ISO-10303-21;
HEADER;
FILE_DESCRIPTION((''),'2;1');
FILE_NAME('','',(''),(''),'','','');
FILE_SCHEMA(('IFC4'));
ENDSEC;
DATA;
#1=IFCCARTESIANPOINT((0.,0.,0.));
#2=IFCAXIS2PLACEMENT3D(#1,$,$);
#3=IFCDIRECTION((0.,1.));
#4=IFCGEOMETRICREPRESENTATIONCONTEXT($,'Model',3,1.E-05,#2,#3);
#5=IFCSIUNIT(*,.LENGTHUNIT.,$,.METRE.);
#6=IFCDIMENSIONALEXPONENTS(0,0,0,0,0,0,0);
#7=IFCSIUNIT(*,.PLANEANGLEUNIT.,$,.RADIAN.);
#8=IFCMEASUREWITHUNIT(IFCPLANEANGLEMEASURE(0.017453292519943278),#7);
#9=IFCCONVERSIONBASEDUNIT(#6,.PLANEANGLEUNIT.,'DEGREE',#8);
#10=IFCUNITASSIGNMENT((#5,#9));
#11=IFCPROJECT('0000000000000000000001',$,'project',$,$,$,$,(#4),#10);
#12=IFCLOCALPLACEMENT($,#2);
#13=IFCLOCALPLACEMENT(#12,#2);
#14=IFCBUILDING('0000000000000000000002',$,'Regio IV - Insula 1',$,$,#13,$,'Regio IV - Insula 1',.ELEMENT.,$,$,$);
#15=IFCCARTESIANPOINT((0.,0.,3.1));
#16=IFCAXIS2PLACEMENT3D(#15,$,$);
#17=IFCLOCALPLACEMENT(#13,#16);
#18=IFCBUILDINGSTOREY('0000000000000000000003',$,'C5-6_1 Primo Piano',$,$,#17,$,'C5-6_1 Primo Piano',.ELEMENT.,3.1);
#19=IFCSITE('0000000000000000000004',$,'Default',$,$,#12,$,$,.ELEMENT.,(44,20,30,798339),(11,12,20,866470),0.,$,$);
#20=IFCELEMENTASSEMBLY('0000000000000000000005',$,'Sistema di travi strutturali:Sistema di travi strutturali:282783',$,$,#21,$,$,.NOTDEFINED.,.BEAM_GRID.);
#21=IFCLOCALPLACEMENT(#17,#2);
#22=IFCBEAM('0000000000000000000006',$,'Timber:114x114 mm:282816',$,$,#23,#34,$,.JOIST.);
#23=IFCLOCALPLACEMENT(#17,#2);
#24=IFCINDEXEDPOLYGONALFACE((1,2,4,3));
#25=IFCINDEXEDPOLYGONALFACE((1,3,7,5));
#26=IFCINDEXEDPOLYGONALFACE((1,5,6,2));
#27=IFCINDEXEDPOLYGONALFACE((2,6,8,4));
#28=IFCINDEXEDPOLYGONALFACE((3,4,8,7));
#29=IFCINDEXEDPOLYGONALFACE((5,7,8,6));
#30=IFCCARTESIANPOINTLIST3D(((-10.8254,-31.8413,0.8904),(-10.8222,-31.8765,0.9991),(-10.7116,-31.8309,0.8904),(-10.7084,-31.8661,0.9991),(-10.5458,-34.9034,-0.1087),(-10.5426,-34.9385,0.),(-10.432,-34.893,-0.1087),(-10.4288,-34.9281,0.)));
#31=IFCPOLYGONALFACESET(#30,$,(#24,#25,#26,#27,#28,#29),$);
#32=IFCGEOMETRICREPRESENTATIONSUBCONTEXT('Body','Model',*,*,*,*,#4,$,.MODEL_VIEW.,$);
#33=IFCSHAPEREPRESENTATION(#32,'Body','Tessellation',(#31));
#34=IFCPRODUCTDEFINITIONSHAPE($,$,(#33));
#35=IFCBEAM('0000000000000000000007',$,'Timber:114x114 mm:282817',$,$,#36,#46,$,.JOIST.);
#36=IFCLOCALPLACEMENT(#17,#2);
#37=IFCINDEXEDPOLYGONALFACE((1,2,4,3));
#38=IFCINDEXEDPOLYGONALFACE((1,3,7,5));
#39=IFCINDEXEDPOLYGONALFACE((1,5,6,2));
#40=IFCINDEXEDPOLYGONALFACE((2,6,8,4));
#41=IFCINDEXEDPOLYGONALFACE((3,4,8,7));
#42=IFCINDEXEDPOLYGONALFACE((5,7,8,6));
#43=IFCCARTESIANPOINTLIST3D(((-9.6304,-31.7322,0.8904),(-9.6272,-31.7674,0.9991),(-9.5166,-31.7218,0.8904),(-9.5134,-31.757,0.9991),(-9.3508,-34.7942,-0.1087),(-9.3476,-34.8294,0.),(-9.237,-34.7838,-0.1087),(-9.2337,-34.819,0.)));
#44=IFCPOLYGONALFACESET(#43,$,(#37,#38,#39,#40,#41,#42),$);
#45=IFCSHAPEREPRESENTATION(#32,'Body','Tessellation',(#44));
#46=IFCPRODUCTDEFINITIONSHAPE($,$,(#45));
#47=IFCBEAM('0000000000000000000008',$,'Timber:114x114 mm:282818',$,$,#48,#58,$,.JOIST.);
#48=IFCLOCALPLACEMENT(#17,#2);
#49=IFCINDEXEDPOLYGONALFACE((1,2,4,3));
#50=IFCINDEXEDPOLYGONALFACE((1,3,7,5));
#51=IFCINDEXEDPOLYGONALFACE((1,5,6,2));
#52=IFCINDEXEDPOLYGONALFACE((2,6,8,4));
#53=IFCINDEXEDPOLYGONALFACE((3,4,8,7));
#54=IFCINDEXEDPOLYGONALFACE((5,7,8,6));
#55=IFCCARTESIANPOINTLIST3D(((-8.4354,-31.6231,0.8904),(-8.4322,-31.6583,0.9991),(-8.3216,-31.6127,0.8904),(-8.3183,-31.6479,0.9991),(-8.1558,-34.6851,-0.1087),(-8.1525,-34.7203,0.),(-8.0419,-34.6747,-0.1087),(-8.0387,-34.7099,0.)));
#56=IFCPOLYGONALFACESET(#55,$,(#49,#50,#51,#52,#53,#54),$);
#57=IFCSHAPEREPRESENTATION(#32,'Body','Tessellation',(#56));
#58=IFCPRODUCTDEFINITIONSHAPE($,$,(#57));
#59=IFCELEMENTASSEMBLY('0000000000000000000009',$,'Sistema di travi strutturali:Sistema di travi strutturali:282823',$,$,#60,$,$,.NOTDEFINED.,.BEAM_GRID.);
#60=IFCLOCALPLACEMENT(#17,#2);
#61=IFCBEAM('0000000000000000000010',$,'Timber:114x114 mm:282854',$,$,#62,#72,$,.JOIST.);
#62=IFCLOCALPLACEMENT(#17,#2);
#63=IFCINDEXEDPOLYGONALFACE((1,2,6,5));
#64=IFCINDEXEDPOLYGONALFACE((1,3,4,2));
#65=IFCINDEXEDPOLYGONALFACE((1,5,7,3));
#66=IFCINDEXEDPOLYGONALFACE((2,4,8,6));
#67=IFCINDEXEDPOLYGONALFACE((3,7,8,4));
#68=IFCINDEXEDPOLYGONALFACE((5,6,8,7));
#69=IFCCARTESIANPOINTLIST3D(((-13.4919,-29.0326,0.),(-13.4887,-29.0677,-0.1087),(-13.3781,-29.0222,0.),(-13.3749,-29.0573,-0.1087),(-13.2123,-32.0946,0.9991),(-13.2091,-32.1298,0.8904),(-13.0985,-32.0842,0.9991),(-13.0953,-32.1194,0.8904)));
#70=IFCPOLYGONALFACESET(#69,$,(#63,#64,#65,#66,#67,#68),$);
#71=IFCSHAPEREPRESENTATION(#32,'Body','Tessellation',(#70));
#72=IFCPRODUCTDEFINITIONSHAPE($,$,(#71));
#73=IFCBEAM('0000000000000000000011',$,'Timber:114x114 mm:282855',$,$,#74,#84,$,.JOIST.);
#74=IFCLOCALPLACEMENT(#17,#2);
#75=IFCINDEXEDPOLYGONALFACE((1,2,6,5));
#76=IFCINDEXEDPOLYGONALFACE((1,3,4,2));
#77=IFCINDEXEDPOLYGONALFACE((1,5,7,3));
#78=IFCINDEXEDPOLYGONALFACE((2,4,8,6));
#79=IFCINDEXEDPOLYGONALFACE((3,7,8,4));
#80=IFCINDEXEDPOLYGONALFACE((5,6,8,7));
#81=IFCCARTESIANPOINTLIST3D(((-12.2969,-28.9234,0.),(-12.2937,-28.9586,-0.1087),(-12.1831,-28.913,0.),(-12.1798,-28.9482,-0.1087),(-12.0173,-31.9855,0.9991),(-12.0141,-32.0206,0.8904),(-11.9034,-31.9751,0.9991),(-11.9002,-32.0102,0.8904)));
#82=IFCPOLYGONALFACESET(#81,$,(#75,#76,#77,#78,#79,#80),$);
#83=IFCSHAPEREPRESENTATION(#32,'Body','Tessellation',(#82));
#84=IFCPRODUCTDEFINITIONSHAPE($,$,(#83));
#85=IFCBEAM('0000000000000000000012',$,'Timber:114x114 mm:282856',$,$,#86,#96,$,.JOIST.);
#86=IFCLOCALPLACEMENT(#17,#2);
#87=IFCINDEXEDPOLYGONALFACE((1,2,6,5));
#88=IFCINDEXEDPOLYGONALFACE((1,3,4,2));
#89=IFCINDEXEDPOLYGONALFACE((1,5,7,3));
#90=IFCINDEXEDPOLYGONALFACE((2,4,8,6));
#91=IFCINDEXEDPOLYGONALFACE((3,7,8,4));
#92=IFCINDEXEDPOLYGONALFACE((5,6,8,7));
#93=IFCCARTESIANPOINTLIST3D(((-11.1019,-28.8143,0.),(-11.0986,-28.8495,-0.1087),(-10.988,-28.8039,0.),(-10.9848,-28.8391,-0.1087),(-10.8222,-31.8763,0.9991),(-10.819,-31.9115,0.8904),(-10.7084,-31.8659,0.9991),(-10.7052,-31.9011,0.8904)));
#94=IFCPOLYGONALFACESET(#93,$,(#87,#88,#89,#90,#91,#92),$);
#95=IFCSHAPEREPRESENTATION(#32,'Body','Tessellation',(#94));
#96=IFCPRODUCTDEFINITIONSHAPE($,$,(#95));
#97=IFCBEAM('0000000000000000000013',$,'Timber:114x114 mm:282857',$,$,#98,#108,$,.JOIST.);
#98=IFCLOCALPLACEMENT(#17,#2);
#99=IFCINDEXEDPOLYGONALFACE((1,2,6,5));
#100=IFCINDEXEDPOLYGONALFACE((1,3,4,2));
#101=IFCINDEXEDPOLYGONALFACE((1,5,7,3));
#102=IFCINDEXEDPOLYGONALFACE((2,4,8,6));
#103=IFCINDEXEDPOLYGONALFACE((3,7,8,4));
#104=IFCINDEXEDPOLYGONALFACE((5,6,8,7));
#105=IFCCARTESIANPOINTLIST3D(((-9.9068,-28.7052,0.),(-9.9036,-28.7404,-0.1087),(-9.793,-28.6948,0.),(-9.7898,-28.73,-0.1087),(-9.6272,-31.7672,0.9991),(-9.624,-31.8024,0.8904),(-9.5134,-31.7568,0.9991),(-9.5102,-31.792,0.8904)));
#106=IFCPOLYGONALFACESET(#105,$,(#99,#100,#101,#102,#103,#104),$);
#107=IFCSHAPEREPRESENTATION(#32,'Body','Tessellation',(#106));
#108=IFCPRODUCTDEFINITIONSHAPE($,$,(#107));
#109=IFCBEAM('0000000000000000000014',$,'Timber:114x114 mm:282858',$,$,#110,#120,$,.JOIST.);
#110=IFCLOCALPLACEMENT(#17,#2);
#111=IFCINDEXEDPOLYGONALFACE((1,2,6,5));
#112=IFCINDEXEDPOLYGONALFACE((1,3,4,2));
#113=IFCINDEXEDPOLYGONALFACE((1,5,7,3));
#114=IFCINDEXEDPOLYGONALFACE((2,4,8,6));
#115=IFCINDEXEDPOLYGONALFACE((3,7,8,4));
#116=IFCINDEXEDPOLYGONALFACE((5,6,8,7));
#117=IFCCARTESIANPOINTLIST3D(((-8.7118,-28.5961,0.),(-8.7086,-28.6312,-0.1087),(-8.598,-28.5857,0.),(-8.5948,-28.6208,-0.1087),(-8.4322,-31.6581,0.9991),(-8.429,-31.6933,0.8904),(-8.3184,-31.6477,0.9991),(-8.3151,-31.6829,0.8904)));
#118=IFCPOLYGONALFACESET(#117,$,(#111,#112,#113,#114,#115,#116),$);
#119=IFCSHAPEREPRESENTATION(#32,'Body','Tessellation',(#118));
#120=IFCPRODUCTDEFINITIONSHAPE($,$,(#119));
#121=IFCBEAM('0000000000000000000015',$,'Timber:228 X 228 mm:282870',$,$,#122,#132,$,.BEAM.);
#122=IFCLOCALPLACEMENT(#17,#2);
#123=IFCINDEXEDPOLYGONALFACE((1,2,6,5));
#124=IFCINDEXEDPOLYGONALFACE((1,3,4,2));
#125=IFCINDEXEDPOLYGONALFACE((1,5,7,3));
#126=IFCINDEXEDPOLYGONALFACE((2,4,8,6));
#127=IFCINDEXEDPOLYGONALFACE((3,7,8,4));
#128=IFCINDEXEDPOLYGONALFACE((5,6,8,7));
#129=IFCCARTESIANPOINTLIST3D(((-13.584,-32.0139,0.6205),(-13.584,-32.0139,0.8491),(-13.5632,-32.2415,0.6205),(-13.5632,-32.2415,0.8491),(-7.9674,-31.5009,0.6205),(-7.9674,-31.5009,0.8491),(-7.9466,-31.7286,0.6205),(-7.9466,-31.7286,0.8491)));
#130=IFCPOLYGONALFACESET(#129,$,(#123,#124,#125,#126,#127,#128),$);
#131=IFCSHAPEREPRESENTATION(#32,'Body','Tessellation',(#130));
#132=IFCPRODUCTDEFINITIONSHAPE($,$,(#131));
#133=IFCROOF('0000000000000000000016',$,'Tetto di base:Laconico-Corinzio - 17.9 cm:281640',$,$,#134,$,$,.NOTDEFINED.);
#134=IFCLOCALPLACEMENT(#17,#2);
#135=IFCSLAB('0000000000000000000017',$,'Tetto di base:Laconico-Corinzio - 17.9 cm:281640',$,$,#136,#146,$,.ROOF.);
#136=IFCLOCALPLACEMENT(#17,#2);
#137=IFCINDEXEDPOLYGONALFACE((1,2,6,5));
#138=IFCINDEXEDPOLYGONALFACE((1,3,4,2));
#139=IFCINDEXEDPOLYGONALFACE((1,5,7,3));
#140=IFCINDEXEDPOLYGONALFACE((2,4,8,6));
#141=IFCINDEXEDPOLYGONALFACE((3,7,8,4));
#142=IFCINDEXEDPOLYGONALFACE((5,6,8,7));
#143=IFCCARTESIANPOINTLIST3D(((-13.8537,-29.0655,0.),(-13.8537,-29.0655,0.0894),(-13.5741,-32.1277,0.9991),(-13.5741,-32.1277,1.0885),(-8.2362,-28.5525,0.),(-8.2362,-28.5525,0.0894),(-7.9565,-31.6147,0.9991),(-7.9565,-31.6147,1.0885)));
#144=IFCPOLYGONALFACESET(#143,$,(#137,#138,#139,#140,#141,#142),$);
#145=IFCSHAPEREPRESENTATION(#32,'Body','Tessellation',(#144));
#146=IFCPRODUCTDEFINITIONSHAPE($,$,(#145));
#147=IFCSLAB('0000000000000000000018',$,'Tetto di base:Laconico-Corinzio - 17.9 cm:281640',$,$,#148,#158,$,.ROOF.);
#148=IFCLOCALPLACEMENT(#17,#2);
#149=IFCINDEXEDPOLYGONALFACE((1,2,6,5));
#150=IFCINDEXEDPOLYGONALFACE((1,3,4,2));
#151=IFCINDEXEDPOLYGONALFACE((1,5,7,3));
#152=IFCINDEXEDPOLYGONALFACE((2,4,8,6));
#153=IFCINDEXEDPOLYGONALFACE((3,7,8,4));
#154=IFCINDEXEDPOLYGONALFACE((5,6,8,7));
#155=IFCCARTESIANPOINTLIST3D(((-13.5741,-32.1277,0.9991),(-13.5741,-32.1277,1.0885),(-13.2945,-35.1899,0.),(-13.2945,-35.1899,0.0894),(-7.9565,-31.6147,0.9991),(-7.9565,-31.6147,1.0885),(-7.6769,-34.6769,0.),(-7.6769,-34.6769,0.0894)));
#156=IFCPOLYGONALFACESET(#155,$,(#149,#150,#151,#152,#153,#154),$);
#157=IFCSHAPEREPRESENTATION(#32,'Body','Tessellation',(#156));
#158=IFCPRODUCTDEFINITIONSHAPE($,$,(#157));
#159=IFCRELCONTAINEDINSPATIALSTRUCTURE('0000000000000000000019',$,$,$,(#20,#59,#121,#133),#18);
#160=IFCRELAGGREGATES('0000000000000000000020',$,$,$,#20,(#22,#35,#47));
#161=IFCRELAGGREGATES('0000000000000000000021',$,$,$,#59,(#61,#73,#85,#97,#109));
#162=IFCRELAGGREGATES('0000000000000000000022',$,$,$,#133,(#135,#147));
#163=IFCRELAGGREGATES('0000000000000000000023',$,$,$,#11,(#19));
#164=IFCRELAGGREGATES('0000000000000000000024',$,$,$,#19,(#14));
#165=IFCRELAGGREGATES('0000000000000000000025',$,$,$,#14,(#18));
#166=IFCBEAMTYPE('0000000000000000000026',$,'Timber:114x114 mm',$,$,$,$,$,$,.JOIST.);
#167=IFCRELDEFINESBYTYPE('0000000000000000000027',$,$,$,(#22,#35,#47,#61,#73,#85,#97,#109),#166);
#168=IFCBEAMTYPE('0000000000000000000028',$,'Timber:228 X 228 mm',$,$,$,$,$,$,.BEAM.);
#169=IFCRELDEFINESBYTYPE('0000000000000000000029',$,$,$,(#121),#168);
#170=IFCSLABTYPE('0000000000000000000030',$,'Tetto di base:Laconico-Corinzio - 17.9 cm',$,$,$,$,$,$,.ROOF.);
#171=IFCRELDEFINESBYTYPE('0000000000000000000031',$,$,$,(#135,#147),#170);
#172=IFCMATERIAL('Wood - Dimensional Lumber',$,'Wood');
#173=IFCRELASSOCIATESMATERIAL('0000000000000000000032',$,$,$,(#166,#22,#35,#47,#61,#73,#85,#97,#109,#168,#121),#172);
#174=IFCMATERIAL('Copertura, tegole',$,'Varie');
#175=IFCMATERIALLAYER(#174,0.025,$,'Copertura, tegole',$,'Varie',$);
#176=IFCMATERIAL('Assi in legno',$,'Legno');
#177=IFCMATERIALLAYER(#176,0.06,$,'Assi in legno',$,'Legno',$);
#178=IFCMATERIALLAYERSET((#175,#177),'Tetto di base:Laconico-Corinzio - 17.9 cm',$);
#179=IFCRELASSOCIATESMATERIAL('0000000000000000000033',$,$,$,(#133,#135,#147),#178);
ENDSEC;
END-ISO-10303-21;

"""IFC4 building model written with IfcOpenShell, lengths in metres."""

from ifc_helpers import new_model, entity, si_unit, converted_unit, direction, frame, frame_2d, origin, origin_2d_with_axis, place, context, subcontext, project, spatial, rectangle, extrude, source, transform, mapped, material, layer, layer_set, material_profile, profile_set, profile_usage, type_object, type_shapes, element, aggregate, save


model = new_model("IFC4")

# Units and contexts
model_context = context("Model", 3, precision=1e-05, world=origin(), true_north=direction((0.0, 1.0)))
body_context = subcontext(model_context, "Body", "Model", "MODEL_VIEW")
ifc_project = project(units=[si_unit("LENGTHUNIT", "METRE"), converted_unit("PLANEANGLEUNIT", "DEGREE", entity("IfcPlaneAngleMeasure", 0.017453292519943278), si_unit("PLANEANGLEUNIT", "RADIAN"), dimensions=[0, 0, 0, 0, 0, 0, 0])], contexts=[model_context])

# Site, building, storey
site_placement = place(None, origin())
site = spatial("IfcSite", under=ifc_project, at=site_placement, Name="Default", CompositionType="ELEMENT", RefLatitude=(44, 20, 30, 798339), RefLongitude=(11, 12, 20, 866470), RefElevation=0.0)
building_placement = place(site_placement, origin())
building = spatial("IfcBuilding", under=site, at=building_placement, Name="Regio IV - Insula 1", LongName="Regio IV - Insula 1", CompositionType="ELEMENT")
storey_placement = place(building_placement, frame((0.0, 0.0, 3.1)))
storey = spatial("IfcBuildingStorey", under=building, at=storey_placement, Name="C5-6_1 Primo Piano", LongName="C5-6_1 Primo Piano", CompositionType="ELEMENT", Elevation=3.1)

# Shared definitions
ifc_material_1 = material(Name="Wood - Dimensional Lumber", Category="Wood")
ifc_material_profile_1 = material_profile(ifc_material_1, rectangle(XDim=5.294, YDim=0.1143, at=origin_2d_with_axis()), Name="114x114 mm")
ifc_profile_set_1 = profile_set([ifc_material_profile_1], Name="114x114 mm")
ifc_profile_usage_1 = profile_usage(ifc_profile_set_1, cardinal=8)

# Element assemblies, beams
assembly_1_placement = place(storey_placement, origin())
assembly_1 = element("IfcElementAssembly", 1, at=assembly_1_placement, inside=storey, Name="Sistema di travi strutturali:Sistema di travi strutturali:282783", AssemblyPlace="NOTDEFINED", PredefinedType="BEAM_GRID")
beam_type_1 = type_object("IfcBeamType", Name="Timber:114x114 mm", PredefinedType="JOIST", material=ifc_profile_set_1)
shared_shape_1 = source(origin(), body_context, "Body", "SweptSolid", [
    extrude(rectangle(XDim=3.233, YDim=0.1143, at=origin_2d_with_axis()), frame((0.0, 0.0, -0.0572), z_axis=(0.0, 0.0, 1.0), x_axis=(-1.0, 0.0, 0.0)), (0.0, 0.0, 1.0), 0.1143),
])
type_shapes(beam_type_1, [shared_shape_1])
beam_1_placement = place(assembly_1_placement, frame((-10.6271, -33.3847, 0.4452), z_axis=(0.028102, -0.307737, 0.951057), x_axis=(0.08649, -0.947116, -0.309017)))
beam_1 = element("IfcBeam", 2, at=beam_1_placement, type_object=beam_type_1, material=ifc_profile_usage_1, Name="Timber:114x114 mm:282816", PredefinedType="JOIST", context=body_context, shape_type="MappedRepresentation", body=[
    mapped(shared_shape_1, transform((0.0, 0.0, 0.0), scale=1.0)),
])
beam_2_placement = place(assembly_1_placement, frame((-9.4321, -33.2756, 0.4452), z_axis=(0.028102, -0.307737, 0.951057), x_axis=(0.08649, -0.947116, -0.309017)))
beam_2 = element("IfcBeam", 3, at=beam_2_placement, type_object=beam_type_1, material=ifc_profile_usage_1, Name="Timber:114x114 mm:282817", PredefinedType="JOIST", context=body_context, shape_type="MappedRepresentation", body=[
    mapped(shared_shape_1, transform((0.0, 0.0, 0.0), scale=1.0)),
])
beam_3_placement = place(assembly_1_placement, frame((-8.237, -33.1665, 0.4452), z_axis=(0.028102, -0.307737, 0.951057), x_axis=(0.08649, -0.947116, -0.309017)))
beam_3 = element("IfcBeam", 4, at=beam_3_placement, type_object=beam_type_1, material=ifc_profile_usage_1, Name="Timber:114x114 mm:282818", PredefinedType="JOIST", context=body_context, shape_type="MappedRepresentation", body=[
    mapped(shared_shape_1, transform((0.0, 0.0, 0.0), scale=1.0)),
])
aggregate(assembly_1, [beam_1, beam_2, beam_3])
assembly_2_placement = place(storey_placement, origin())
assembly_2 = element("IfcElementAssembly", 5, at=assembly_2_placement, inside=storey, Name="Sistema di travi strutturali:Sistema di travi strutturali:282823", AssemblyPlace="NOTDEFINED", PredefinedType="BEAM_GRID")
beam_4_placement = place(assembly_2_placement, frame((-13.2936, -30.576, 0.4452), z_axis=(-0.028102, 0.307737, 0.951057), x_axis=(0.08649, -0.947116, 0.309017)))
beam_4 = element("IfcBeam", 6, at=beam_4_placement, type_object=beam_type_1, material=ifc_profile_usage_1, Name="Timber:114x114 mm:282854", PredefinedType="JOIST", context=body_context, shape_type="MappedRepresentation", body=[
    mapped(shared_shape_1, transform((0.0, 0.0, 0.0), scale=1.0)),
])
beam_5_placement = place(assembly_2_placement, frame((-12.0986, -30.4668, 0.4452), z_axis=(-0.028102, 0.307737, 0.951057), x_axis=(0.08649, -0.947116, 0.309017)))
beam_5 = element("IfcBeam", 7, at=beam_5_placement, type_object=beam_type_1, material=ifc_profile_usage_1, Name="Timber:114x114 mm:282855", PredefinedType="JOIST", context=body_context, shape_type="MappedRepresentation", body=[
    mapped(shared_shape_1, transform((0.0, 0.0, 0.0), scale=1.0)),
])
beam_6_placement = place(assembly_2_placement, frame((-10.9035, -30.3577, 0.4452), z_axis=(-0.028102, 0.307737, 0.951057), x_axis=(0.08649, -0.947116, 0.309017)))
beam_6 = element("IfcBeam", 8, at=beam_6_placement, type_object=beam_type_1, material=ifc_profile_usage_1, Name="Timber:114x114 mm:282856", PredefinedType="JOIST", context=body_context, shape_type="MappedRepresentation", body=[
    mapped(shared_shape_1, transform((0.0, 0.0, 0.0), scale=1.0)),
])
beam_7_placement = place(assembly_2_placement, frame((-9.7085, -30.2486, 0.4452), z_axis=(-0.028102, 0.307737, 0.951057), x_axis=(0.08649, -0.947116, 0.309017)))
beam_7 = element("IfcBeam", 9, at=beam_7_placement, type_object=beam_type_1, material=ifc_profile_usage_1, Name="Timber:114x114 mm:282857", PredefinedType="JOIST", context=body_context, shape_type="MappedRepresentation", body=[
    mapped(shared_shape_1, transform((0.0, 0.0, 0.0), scale=1.0)),
])
beam_8_placement = place(assembly_2_placement, frame((-8.5135, -30.1395, 0.4452), z_axis=(-0.028102, 0.307737, 0.951057), x_axis=(0.08649, -0.947116, 0.309017)))
beam_8 = element("IfcBeam", 10, at=beam_8_placement, type_object=beam_type_1, material=ifc_profile_usage_1, Name="Timber:114x114 mm:282858", PredefinedType="JOIST", context=body_context, shape_type="MappedRepresentation", body=[
    mapped(shared_shape_1, transform((0.0, 0.0, 0.0), scale=1.0)),
])
aggregate(assembly_2, [beam_4, beam_5, beam_6, beam_7, beam_8])

# Beam
ifc_material_profile_2 = material_profile(ifc_material_1, rectangle(XDim=8.091, YDim=0.2286, at=frame_2d((0.0, 0.0), x_axis=(1.0, 0.0))), Name="228 X 228 mm")
ifc_profile_set_2 = profile_set([ifc_material_profile_2], Name="228 X 228 mm")
ifc_profile_usage_2 = profile_usage(ifc_profile_set_2, cardinal=1)
beam_type_2 = type_object("IfcBeamType", Name="Timber:228 X 228 mm", PredefinedType="BEAM", material=ifc_profile_set_2)
shared_shape_2 = source(origin(), body_context, "Body", "SweptSolid", [
    extrude(rectangle(XDim=5.64, YDim=0.2286, at=origin_2d_with_axis()), frame((0.0, 0.0, -0.1143), z_axis=(0.0, 0.0, 1.0), x_axis=(-1.0, 0.0, 0.0)), (0.0, 0.0, 1.0), 0.2286),
])
type_shapes(beam_type_2, [shared_shape_2])
beam_9_placement = place(storey_placement, frame((-10.7653, -31.8712, 0.7348), z_axis=(0.0, 0.0, 1.0), x_axis=(-0.995856, -0.090941, 0.0)))
element("IfcBeam", 11, at=beam_9_placement, inside=storey, type_object=beam_type_2, material=ifc_profile_usage_2, Name="Timber:228 X 228 mm:282870", PredefinedType="BEAM", context=body_context, shape_type="MappedRepresentation", body=[
    mapped(shared_shape_2, transform((0.0, 0.0, 0.0), scale=1.0)),
])

# Roof, slabs
ifc_material_2 = material(Name="Copertura, tegole", Category="Varie")
ifc_layer_1 = layer(ifc_material_2, 0.025, Name="Copertura, tegole", Category="Varie")
ifc_material_3 = material(Name="Assi in legno", Category="Legno")
ifc_layer_2 = layer(ifc_material_3, 0.06, Name="Assi in legno", Category="Legno")
ifc_layer_set = layer_set([ifc_layer_1, ifc_layer_2], Name="Tetto di base:Laconico-Corinzio - 17.9 cm")
slab_type = type_object("IfcSlabType", Name="Tetto di base:Laconico-Corinzio - 17.9 cm", PredefinedType="ROOF")
roof_1_placement = place(storey_placement, frame((-13.8537, -35.1899, 0.0)))
roof_1 = element("IfcRoof", 12, at=roof_1_placement, inside=storey, material=ifc_layer_set, Name="Tetto di base:Laconico-Corinzio - 17.9 cm:281640", PredefinedType="NOTDEFINED")
slab_1_placement = place(roof_1_placement, origin())
slab_1 = element("IfcSlab", 13, at=slab_1_placement, type_object=slab_type, material=ifc_layer_set, Name="Tetto di base:Laconico-Corinzio - 17.9 cm:281640", PredefinedType="ROOF", context=body_context, shape_type="SweptSolid", body=[
    extrude(rectangle(XDim=3.2332, YDim=5.6409, at=frame_2d((0.0, 0.0), x_axis=(0.086524, -0.99625))), frame((2.9486, 4.8498, 0.4996), z_axis=(-0.028102, 0.307737, 0.951057), x_axis=(0.999605, 0.008651, 0.026737)), (0.026737, -0.307858, 0.951057), 0.0894),
])
slab_2_placement = place(roof_1_placement, origin())
slab_2 = element("IfcSlab", 14, at=slab_2_placement, type_object=slab_type, material=ifc_layer_set, Name="Tetto di base:Laconico-Corinzio - 17.9 cm:281640", PredefinedType="ROOF", context=body_context, shape_type="SweptSolid", body=[
    extrude(rectangle(XDim=5.6409, YDim=3.2332, at=frame_2d((0.0, 0.0), x_axis=(-0.99625, -0.086524))), frame((3.2282, 1.7876, 0.4996), z_axis=(0.028102, -0.307737, 0.951057), x_axis=(0.999605, 0.008651, -0.026737)), (-0.026737, 0.307858, 0.951057), 0.0894),
])
aggregate(roof_1, [slab_1, slab_2])

save(model, "model.ifc")
